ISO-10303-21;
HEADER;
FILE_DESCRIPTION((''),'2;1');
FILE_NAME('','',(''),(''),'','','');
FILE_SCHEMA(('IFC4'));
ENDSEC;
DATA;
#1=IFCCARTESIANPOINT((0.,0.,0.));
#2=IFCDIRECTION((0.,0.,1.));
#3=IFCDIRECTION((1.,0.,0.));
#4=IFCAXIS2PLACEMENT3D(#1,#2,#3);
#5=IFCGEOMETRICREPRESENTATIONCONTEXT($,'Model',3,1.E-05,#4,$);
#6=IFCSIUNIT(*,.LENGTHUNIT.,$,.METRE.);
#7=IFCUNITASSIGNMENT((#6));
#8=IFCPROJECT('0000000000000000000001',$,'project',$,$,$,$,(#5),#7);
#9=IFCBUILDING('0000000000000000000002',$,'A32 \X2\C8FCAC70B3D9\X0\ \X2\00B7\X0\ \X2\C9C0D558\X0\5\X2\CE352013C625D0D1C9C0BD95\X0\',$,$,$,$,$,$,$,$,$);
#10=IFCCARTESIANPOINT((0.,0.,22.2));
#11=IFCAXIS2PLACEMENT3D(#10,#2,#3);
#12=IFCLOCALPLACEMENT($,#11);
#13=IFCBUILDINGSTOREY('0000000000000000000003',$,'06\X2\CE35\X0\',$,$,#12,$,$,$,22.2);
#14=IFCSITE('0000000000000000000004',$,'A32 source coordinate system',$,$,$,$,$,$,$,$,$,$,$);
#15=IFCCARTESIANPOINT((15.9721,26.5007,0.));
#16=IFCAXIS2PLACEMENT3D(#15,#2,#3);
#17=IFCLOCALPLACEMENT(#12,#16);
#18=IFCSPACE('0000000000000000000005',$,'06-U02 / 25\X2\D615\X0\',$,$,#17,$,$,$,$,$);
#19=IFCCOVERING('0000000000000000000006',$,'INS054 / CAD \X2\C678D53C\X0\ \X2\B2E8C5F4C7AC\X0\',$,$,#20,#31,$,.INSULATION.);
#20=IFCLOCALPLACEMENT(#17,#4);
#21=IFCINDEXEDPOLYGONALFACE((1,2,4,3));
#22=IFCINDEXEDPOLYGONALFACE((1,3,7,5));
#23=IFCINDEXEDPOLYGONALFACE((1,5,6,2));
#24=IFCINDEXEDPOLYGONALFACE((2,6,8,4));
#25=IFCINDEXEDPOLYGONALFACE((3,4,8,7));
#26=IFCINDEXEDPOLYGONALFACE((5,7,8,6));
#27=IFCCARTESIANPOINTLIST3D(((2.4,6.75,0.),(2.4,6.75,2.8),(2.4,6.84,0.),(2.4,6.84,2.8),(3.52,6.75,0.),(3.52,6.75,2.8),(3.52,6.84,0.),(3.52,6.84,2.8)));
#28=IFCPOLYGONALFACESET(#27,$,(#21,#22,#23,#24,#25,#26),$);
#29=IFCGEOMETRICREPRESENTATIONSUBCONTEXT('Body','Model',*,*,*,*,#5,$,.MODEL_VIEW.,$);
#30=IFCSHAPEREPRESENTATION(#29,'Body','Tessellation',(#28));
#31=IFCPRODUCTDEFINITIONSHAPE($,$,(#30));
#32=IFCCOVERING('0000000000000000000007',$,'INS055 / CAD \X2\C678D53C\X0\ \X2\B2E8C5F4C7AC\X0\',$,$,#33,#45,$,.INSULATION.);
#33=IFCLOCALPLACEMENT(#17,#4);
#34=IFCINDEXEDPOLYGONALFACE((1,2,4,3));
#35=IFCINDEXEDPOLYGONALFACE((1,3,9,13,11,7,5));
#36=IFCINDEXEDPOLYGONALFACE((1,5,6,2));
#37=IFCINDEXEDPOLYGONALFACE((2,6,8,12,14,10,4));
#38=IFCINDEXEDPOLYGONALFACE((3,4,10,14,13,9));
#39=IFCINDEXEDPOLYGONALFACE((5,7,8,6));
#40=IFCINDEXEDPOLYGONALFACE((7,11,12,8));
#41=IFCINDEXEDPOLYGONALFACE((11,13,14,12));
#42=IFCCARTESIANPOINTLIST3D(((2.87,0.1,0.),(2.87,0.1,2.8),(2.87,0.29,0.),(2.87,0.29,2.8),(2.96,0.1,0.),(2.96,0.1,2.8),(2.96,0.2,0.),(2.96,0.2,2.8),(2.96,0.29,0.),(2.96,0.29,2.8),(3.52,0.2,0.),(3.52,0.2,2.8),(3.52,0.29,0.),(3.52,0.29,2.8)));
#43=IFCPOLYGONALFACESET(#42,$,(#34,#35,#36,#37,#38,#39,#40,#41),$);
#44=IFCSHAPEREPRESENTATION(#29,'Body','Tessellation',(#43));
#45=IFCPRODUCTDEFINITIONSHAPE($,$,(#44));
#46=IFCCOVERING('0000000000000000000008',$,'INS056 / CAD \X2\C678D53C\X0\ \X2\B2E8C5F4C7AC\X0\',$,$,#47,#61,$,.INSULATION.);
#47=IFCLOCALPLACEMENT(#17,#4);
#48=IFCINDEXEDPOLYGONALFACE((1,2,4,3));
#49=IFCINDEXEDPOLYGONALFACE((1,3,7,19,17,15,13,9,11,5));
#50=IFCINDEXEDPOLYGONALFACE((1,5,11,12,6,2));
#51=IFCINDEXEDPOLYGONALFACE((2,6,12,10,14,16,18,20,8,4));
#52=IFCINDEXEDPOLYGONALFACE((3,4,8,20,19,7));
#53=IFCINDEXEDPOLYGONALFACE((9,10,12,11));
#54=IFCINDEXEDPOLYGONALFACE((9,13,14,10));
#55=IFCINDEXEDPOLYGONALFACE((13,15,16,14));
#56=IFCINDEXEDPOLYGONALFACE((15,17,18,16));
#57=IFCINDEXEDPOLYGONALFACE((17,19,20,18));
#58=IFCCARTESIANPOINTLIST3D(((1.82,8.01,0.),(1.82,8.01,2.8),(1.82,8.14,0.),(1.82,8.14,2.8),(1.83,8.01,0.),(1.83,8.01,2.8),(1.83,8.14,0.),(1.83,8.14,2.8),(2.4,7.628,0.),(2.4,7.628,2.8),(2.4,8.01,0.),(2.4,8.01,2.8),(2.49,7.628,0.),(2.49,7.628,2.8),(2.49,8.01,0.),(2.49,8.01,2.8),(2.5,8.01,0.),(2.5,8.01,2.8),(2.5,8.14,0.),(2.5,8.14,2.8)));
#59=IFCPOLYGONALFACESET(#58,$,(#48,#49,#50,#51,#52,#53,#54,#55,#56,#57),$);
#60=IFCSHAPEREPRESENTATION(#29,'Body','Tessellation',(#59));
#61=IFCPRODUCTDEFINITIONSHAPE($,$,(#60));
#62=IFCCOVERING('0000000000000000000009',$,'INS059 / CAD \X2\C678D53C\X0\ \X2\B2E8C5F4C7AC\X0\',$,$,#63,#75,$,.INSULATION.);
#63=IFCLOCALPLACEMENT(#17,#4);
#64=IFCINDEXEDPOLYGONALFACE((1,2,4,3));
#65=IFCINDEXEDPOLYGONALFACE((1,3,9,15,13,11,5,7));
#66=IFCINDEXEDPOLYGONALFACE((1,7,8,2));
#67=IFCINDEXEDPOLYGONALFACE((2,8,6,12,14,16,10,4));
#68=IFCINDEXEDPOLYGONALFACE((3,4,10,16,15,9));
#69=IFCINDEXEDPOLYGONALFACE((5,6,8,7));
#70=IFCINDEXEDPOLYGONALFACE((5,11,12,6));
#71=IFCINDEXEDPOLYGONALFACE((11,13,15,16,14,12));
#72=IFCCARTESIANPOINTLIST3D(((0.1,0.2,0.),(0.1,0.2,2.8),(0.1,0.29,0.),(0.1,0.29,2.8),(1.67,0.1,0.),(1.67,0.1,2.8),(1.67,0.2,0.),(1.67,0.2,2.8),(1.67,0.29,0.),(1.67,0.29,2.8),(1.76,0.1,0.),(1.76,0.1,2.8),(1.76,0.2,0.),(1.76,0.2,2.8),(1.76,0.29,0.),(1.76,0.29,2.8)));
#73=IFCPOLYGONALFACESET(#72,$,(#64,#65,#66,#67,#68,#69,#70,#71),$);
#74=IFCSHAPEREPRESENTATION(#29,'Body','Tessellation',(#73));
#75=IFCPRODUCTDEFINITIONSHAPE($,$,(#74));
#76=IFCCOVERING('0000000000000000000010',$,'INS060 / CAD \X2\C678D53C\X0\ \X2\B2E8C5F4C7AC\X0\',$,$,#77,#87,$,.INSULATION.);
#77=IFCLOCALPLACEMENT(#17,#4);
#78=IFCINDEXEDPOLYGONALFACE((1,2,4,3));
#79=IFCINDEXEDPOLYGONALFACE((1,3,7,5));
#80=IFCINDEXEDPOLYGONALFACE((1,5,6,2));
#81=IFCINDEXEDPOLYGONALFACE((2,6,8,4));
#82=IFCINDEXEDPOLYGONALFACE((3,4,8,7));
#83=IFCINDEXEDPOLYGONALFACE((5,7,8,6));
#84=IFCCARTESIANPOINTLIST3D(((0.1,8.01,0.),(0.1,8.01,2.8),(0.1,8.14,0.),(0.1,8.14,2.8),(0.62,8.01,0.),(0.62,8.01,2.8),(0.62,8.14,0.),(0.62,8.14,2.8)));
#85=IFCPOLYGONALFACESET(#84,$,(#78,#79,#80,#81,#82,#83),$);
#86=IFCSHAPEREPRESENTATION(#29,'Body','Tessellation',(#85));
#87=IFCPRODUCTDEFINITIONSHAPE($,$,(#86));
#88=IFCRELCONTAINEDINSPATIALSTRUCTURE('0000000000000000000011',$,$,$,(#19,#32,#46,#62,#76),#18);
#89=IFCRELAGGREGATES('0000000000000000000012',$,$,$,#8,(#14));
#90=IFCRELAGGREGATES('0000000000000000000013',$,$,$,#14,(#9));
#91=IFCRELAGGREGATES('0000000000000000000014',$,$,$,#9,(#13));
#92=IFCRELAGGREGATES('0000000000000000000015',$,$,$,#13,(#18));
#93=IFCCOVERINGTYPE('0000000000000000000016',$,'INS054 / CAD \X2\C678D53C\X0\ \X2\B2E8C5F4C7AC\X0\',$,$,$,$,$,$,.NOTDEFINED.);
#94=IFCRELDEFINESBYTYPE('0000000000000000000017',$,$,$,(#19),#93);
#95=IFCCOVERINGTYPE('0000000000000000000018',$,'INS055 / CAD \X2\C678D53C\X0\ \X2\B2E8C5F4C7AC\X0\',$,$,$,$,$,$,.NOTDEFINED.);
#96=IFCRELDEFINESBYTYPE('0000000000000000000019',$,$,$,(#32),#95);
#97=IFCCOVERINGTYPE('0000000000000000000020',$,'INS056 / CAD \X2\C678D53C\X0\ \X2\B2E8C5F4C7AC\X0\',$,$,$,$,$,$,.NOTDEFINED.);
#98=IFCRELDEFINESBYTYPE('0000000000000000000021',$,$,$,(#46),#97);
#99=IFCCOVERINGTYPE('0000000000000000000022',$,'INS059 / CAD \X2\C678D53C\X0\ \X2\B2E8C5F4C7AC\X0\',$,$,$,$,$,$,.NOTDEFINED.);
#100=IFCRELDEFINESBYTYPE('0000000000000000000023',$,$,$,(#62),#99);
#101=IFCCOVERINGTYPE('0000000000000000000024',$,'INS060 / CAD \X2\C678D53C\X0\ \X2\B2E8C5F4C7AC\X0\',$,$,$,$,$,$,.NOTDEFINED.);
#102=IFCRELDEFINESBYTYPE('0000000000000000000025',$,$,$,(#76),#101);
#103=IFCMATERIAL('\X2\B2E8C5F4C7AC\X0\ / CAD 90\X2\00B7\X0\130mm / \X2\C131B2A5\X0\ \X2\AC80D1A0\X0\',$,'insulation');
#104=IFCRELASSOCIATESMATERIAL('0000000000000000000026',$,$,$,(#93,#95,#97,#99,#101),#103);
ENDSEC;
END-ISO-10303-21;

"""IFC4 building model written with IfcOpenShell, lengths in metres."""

from ifc_helpers import new_model, si_unit, frame, origin, origin_with_axes, place, context, subcontext, project, spatial, polyline, outline, extrude, source, transform, mapped, material, type_object, type_shapes, element, save


model = new_model("IFC4")

# Units and contexts
model_context = context("Model", 3, precision=1e-05, world=origin_with_axes())
body_context = subcontext(model_context, "Body", "Model", "MODEL_VIEW")
ifc_project = project(units=[si_unit("LENGTHUNIT", "METRE")], contexts=[model_context])

# Site, building, storey, space
storey_placement = place(None, frame((0.0, 0.0, 22.2), z_axis=(0.0, 0.0, 1.0), x_axis=(1.0, 0.0, 0.0)))
space_placement = place(storey_placement, frame((15.9721, 26.5007, 0.0), z_axis=(0.0, 0.0, 1.0), x_axis=(1.0, 0.0, 0.0)))
site = spatial("IfcSite", under=ifc_project, Name="A32 source coordinate system")
building = spatial("IfcBuilding", under=site, Name="A32 주거동 · 지하5층–옥탑지붕")
storey = spatial("IfcBuildingStorey", under=building, at=storey_placement, Name="06층", Elevation=22.2)
space = spatial("IfcSpace", under=storey, at=space_placement, Name="06-U02 / 25형")

# Coverings
ifc_material = material(Name="단열재 / CAD 90·130mm / 성능 검토", Category="insulation")
covering_type_1 = type_object("IfcCoveringType", Name="INS054 / CAD 외피 단열재", PredefinedType="NOTDEFINED", material=ifc_material)
shared_shape_1 = source(origin(), body_context, "Body", "SweptSolid", [
    extrude(outline(polyline([(2.4, 6.84), (3.52, 6.84), (3.52, 6.75), (2.4, 6.75), (2.4, 6.84)])), origin(), (0.0, 0.0, 1.0), 2.8),
])
type_shapes(covering_type_1, [shared_shape_1])
covering_1_placement = place(space_placement, origin_with_axes())
element("IfcCovering", 1, at=covering_1_placement, inside=space, type_object=covering_type_1, Name="INS054 / CAD 외피 단열재", PredefinedType="INSULATION", context=body_context, shape_type="MappedRepresentation", body=[
    mapped(shared_shape_1, transform((0.0, 0.0, 0.0), scale=1.0)),
])
covering_type_2 = type_object("IfcCoveringType", Name="INS055 / CAD 외피 단열재", PredefinedType="NOTDEFINED", material=ifc_material)
shared_shape_2 = source(origin(), body_context, "Body", "SweptSolid", [
    extrude(outline(polyline([(2.87, 0.29), (2.96, 0.29), (3.52, 0.29), (3.52, 0.2), (2.96, 0.2), (2.96, 0.1), (2.87, 0.1), (2.87, 0.29)])), origin(), (0.0, 0.0, 1.0), 2.8),
])
type_shapes(covering_type_2, [shared_shape_2])
covering_2_placement = place(space_placement, origin_with_axes())
element("IfcCovering", 2, at=covering_2_placement, inside=space, type_object=covering_type_2, Name="INS055 / CAD 외피 단열재", PredefinedType="INSULATION", context=body_context, shape_type="MappedRepresentation", body=[
    mapped(shared_shape_2, transform((0.0, 0.0, 0.0), scale=1.0)),
])
covering_type_3 = type_object("IfcCoveringType", Name="INS056 / CAD 외피 단열재", PredefinedType="NOTDEFINED", material=ifc_material)
shared_shape_3 = source(origin(), body_context, "Body", "SweptSolid", [
    extrude(outline(polyline([(2.49, 7.628), (2.4, 7.628), (2.4, 8.01), (1.83, 8.01), (1.82, 8.01), (1.82, 8.14), (1.83, 8.14), (2.5, 8.14), (2.5, 8.01), (2.49, 8.01), (2.49, 7.628)])), origin(), (0.0, 0.0, 1.0), 2.8),
])
type_shapes(covering_type_3, [shared_shape_3])
covering_3_placement = place(space_placement, origin_with_axes())
element("IfcCovering", 3, at=covering_3_placement, inside=space, type_object=covering_type_3, Name="INS056 / CAD 외피 단열재", PredefinedType="INSULATION", context=body_context, shape_type="MappedRepresentation", body=[
    mapped(shared_shape_3, transform((0.0, 0.0, 0.0), scale=1.0)),
])
covering_type_4 = type_object("IfcCoveringType", Name="INS059 / CAD 외피 단열재", PredefinedType="NOTDEFINED", material=ifc_material)
shared_shape_4 = source(origin(), body_context, "Body", "SweptSolid", [
    extrude(outline(polyline([(1.76, 0.1), (1.67, 0.1), (1.67, 0.2), (0.1, 0.2), (0.1, 0.29), (1.67, 0.29), (1.76, 0.29), (1.76, 0.2), (1.76, 0.1)])), origin(), (0.0, 0.0, 1.0), 2.8),
])
type_shapes(covering_type_4, [shared_shape_4])
covering_4_placement = place(space_placement, origin_with_axes())
element("IfcCovering", 4, at=covering_4_placement, inside=space, type_object=covering_type_4, Name="INS059 / CAD 외피 단열재", PredefinedType="INSULATION", context=body_context, shape_type="MappedRepresentation", body=[
    mapped(shared_shape_4, transform((0.0, 0.0, 0.0), scale=1.0)),
])
covering_type_5 = type_object("IfcCoveringType", Name="INS060 / CAD 외피 단열재", PredefinedType="NOTDEFINED", material=ifc_material)
shared_shape_5 = source(origin(), body_context, "Body", "SweptSolid", [
    extrude(outline(polyline([(0.1, 8.01), (0.1, 8.14), (0.62, 8.14), (0.62, 8.01), (0.1, 8.01)])), origin(), (0.0, 0.0, 1.0), 2.8),
])
type_shapes(covering_type_5, [shared_shape_5])
covering_5_placement = place(space_placement, origin_with_axes())
element("IfcCovering", 5, at=covering_5_placement, inside=space, type_object=covering_type_5, Name="INS060 / CAD 외피 단열재", PredefinedType="INSULATION", context=body_context, shape_type="MappedRepresentation", body=[
    mapped(shared_shape_5, transform((0.0, 0.0, 0.0), scale=1.0)),
])

save(model, "model.ifc")
